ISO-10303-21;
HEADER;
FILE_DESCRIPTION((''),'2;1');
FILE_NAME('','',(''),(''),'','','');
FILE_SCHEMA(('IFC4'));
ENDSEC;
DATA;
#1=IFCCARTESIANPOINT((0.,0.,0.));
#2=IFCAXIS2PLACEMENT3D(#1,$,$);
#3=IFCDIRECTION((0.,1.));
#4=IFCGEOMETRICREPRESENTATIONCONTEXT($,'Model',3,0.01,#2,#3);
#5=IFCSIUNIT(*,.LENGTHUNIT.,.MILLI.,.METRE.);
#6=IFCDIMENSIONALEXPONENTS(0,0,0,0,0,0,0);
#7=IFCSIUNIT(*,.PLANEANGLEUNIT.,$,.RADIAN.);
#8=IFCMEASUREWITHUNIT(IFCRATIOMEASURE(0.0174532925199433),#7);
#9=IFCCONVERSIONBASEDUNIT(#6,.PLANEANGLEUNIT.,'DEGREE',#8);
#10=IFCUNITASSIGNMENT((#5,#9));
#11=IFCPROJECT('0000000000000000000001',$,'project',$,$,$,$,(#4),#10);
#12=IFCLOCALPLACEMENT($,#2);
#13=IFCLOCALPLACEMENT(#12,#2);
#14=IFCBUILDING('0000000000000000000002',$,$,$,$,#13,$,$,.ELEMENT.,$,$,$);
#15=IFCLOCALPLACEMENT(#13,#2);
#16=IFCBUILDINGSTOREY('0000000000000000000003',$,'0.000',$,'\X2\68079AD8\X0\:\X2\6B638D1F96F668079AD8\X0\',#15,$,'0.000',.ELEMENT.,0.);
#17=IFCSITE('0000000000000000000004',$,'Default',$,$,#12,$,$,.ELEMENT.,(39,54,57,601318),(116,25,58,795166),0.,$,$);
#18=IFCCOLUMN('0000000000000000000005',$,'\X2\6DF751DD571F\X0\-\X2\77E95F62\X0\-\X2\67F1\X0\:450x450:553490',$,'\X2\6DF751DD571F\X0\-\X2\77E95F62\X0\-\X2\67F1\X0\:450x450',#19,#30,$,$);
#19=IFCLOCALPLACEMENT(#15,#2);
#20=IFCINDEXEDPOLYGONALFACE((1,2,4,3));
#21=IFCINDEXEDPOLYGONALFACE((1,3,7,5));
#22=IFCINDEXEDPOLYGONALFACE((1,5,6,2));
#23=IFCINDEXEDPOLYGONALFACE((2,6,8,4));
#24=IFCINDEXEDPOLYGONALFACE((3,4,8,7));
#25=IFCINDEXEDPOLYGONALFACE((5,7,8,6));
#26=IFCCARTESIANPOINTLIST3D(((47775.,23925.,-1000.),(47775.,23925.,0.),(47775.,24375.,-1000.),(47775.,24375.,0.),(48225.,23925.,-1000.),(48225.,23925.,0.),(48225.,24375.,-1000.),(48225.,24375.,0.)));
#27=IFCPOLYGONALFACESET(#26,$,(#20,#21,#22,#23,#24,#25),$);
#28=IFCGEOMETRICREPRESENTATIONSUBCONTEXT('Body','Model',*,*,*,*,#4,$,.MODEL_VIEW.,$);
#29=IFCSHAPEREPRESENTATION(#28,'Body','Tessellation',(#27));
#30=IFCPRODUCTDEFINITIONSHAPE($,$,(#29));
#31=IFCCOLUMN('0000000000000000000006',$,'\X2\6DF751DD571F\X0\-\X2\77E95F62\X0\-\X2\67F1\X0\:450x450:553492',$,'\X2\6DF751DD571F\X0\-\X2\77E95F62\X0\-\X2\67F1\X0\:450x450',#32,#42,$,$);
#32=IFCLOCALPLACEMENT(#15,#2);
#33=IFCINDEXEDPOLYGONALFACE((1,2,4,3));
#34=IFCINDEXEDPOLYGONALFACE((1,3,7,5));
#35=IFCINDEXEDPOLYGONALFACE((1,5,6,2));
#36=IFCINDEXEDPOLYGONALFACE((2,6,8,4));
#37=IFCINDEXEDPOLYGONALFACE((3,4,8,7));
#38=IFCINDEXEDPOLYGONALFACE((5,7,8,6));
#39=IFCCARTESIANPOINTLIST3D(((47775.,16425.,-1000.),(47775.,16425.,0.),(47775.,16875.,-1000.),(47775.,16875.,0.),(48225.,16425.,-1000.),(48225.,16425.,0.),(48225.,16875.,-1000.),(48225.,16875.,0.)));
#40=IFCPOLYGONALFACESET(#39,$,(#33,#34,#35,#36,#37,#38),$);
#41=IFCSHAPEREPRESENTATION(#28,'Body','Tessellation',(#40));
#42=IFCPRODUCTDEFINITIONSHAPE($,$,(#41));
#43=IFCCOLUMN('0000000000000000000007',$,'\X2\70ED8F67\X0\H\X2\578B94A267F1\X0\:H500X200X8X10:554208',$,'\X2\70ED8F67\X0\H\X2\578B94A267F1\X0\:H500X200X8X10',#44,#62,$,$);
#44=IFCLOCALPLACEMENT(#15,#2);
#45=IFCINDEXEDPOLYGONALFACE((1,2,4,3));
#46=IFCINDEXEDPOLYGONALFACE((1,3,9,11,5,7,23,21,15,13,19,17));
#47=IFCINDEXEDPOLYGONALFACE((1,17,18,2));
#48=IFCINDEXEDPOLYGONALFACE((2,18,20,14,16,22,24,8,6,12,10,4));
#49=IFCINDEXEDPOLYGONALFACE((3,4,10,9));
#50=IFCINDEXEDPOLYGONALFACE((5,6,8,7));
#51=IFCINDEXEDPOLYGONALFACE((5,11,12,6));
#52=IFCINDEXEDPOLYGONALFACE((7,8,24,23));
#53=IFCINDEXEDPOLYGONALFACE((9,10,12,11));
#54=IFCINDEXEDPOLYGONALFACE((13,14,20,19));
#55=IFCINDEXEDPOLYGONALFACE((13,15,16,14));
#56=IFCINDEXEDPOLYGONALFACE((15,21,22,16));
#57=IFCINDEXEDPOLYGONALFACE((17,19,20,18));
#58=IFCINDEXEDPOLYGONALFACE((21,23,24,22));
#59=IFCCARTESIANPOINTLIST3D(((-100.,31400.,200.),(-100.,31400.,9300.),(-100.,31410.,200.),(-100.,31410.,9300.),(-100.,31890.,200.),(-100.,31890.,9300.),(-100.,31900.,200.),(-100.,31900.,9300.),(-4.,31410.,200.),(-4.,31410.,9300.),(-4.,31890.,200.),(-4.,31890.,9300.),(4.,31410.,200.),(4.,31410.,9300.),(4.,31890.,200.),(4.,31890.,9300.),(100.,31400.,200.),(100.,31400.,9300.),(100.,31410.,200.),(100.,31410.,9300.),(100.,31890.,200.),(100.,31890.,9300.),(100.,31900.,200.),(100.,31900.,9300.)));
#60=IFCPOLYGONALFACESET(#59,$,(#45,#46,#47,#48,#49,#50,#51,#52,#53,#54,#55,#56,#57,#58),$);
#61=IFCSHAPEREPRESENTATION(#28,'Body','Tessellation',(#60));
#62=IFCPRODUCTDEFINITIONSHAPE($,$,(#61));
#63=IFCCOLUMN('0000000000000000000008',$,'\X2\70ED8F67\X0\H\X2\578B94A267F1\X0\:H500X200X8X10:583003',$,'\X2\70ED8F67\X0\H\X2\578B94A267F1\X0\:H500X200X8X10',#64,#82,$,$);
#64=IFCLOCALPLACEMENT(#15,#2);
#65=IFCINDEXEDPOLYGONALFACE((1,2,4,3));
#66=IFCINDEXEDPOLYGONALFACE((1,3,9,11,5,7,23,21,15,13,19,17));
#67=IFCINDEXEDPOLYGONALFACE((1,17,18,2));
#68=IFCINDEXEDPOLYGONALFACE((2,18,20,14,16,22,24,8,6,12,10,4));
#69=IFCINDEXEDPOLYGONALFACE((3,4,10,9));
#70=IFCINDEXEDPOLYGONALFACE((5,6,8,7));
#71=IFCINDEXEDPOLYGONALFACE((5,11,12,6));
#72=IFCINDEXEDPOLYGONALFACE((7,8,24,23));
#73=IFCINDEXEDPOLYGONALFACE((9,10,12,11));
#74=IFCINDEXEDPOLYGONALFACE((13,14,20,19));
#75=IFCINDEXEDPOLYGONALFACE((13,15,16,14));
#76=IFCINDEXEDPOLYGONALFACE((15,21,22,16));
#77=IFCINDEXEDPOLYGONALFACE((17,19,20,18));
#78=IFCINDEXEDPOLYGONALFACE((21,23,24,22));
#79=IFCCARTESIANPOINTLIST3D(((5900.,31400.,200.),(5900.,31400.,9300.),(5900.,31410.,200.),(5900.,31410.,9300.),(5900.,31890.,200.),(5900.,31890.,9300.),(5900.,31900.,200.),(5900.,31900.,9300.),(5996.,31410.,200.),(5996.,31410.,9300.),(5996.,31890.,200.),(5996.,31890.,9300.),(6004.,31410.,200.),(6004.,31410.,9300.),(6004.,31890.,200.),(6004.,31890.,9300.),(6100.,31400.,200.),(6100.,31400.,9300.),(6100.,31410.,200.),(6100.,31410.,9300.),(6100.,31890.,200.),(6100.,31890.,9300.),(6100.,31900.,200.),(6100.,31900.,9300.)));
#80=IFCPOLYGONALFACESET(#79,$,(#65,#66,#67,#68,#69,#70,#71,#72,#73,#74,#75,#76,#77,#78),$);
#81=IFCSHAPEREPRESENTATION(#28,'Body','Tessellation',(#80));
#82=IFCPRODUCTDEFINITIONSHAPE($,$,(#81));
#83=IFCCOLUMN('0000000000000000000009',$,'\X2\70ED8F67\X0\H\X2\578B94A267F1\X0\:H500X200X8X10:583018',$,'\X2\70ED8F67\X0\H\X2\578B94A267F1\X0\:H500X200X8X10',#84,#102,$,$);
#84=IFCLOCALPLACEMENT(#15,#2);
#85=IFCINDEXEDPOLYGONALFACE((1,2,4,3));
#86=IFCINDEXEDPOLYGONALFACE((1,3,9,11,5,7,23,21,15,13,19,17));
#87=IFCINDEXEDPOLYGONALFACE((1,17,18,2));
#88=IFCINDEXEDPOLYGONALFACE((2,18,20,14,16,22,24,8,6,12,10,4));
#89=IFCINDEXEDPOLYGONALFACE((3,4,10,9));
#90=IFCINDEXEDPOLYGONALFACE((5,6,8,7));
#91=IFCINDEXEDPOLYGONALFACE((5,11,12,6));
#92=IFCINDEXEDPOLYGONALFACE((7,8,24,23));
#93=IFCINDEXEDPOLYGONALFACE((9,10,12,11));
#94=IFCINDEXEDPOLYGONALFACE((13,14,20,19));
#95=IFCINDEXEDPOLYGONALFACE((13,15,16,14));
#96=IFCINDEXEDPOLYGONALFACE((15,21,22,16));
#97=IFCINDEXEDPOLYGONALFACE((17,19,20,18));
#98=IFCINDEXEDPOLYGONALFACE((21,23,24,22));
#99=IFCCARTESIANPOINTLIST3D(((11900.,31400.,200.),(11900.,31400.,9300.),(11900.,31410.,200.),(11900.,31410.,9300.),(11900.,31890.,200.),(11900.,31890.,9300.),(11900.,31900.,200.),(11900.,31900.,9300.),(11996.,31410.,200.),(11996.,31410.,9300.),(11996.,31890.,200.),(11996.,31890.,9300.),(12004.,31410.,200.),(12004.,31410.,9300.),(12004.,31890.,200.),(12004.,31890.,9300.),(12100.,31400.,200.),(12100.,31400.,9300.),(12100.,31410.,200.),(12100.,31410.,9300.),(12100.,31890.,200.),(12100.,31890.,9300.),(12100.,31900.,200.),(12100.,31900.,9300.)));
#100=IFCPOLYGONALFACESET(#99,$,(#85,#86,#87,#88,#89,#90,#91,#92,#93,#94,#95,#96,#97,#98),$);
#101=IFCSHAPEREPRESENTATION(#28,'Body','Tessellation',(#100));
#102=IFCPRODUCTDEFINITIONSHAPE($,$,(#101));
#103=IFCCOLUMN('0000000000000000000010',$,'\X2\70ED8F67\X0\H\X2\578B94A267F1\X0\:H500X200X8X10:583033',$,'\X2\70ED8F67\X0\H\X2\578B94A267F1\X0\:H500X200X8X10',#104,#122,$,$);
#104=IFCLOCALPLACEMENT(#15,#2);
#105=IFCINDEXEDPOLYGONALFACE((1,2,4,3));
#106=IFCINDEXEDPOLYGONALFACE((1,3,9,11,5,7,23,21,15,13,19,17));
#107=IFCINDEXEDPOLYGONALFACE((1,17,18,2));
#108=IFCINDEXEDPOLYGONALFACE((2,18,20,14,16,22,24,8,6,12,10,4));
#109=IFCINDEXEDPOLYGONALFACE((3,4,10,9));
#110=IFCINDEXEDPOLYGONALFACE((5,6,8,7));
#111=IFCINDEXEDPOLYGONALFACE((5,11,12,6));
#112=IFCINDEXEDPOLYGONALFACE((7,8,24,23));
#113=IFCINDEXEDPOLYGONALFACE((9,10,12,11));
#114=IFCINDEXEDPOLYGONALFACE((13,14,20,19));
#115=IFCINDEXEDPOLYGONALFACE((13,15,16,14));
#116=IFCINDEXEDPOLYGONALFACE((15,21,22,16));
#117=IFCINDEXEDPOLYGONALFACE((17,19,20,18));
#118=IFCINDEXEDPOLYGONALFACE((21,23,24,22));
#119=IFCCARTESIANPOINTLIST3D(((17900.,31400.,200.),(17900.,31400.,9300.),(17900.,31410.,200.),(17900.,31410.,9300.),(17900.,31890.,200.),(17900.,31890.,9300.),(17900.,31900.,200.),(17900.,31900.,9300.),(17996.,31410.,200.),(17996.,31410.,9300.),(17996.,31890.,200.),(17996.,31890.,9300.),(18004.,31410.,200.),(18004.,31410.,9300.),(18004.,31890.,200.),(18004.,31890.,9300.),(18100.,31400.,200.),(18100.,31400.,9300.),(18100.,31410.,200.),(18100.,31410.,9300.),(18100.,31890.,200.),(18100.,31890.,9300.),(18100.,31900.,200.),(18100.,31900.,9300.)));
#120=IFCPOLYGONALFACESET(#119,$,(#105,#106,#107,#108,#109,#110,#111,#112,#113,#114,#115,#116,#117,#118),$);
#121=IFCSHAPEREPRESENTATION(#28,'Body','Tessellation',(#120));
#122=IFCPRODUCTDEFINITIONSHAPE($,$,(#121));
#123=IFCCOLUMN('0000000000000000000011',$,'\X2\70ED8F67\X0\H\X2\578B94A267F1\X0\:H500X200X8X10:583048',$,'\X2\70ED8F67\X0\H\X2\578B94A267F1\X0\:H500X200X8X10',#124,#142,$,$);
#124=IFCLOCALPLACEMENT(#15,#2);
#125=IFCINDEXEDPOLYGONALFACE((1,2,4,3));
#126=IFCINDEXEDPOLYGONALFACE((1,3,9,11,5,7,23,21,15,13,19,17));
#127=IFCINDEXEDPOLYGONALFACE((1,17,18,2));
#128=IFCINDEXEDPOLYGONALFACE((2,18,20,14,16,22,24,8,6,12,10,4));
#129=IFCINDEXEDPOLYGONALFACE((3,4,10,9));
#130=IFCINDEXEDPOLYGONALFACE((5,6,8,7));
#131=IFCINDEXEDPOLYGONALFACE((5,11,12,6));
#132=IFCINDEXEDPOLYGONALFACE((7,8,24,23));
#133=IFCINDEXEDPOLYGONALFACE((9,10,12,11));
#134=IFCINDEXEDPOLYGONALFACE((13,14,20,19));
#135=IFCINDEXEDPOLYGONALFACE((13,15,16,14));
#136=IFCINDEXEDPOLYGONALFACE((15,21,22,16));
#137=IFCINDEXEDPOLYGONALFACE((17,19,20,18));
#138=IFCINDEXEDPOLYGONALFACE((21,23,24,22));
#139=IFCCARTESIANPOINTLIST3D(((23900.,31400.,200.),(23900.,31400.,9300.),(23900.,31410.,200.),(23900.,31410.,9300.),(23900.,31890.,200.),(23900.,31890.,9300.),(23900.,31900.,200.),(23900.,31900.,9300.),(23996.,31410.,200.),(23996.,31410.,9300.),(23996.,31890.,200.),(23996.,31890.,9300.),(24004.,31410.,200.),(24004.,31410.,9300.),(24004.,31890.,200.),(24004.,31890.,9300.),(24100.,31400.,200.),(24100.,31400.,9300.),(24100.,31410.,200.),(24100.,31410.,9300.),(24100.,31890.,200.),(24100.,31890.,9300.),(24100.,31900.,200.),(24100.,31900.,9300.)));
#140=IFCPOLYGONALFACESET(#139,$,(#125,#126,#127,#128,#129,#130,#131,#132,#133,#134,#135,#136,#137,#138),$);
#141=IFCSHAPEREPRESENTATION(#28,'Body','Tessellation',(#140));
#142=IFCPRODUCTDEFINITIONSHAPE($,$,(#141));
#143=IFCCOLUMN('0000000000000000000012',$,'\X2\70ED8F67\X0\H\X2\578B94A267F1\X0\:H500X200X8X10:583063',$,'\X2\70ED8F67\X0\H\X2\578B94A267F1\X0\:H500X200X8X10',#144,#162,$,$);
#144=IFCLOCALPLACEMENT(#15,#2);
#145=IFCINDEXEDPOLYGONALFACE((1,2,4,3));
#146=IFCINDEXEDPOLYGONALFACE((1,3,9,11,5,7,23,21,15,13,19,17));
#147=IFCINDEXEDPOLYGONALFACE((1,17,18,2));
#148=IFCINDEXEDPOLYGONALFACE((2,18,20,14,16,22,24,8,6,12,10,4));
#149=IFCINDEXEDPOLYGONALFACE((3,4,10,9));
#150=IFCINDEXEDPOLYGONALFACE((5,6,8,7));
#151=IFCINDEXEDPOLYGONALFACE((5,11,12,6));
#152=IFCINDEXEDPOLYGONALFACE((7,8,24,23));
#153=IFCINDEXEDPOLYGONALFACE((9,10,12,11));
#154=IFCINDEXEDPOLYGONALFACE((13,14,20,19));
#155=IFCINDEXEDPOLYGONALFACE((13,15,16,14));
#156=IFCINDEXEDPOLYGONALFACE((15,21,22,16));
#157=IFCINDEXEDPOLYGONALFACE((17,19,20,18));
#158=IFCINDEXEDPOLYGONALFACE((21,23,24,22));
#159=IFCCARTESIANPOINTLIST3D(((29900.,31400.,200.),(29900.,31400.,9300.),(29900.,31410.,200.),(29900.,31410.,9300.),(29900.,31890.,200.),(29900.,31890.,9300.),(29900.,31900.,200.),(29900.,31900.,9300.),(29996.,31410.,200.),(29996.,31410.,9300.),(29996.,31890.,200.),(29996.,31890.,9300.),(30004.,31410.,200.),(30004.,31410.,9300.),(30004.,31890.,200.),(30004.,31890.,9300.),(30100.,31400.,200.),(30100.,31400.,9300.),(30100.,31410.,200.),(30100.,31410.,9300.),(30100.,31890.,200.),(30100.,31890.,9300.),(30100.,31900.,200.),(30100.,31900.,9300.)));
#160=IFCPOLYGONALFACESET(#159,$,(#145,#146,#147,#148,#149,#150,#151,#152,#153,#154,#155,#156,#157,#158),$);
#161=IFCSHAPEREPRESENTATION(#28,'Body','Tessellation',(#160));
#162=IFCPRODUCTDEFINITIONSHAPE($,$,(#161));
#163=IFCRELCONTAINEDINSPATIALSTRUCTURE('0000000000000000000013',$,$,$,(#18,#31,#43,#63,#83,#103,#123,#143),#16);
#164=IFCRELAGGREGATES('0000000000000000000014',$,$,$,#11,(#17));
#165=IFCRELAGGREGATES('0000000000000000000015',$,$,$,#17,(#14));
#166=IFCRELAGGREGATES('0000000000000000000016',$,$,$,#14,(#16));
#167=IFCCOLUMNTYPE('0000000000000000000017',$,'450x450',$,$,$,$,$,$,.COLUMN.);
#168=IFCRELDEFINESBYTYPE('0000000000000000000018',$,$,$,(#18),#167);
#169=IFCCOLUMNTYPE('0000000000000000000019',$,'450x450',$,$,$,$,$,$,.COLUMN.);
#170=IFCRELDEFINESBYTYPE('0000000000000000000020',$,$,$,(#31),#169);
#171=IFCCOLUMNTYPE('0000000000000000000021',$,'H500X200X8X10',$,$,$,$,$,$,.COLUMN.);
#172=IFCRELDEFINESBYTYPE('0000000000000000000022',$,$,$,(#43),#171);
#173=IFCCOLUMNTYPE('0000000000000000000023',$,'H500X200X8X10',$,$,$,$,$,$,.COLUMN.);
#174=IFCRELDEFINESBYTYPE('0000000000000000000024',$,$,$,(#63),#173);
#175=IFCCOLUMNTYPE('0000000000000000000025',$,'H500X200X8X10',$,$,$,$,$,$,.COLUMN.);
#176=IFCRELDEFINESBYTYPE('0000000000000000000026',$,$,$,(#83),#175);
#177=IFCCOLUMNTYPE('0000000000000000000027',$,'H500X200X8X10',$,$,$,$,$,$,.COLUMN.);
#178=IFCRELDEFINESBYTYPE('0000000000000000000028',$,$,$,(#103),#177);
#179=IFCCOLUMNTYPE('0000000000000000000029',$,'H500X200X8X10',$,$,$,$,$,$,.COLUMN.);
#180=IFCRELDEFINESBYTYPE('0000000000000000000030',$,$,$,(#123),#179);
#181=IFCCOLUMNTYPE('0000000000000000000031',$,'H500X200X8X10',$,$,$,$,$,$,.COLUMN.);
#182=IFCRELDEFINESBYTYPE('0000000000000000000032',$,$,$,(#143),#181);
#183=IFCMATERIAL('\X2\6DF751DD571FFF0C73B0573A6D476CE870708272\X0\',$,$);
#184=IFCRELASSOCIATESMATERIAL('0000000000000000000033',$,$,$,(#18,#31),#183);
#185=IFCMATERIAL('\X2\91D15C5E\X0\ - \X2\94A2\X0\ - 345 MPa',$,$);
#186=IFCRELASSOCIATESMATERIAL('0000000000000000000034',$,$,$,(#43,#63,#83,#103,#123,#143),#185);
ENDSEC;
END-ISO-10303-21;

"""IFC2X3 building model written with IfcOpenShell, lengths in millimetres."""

from ifc_helpers import new_model, entity, si_unit, converted_unit, direction, frame, origin, origin_2d_with_axis, place, context, subcontext, project, spatial, polyline, rectangle, outline, extrude, source, transform, mapped, material, type_object, type_shapes, element, save


model = new_model("IFC2X3")

# Units and contexts
model_context = context("Model", 3, precision=0.01, world=origin(), true_north=direction((0.0, 1.0)))
body_context = subcontext(model_context, "Body", "Model", "MODEL_VIEW")
ifc_project = project(units=[si_unit("LENGTHUNIT", "METRE", prefix="MILLI"), converted_unit("PLANEANGLEUNIT", "DEGREE", entity("IfcRatioMeasure", 0.0174532925199433), si_unit("PLANEANGLEUNIT", "RADIAN"), dimensions=[0, 0, 0, 0, 0, 0, 0])], contexts=[model_context])

# Site, building, storey
site_placement = place(None, origin())
site = spatial("IfcSite", under=ifc_project, at=site_placement, Name="Default", CompositionType="ELEMENT", RefLatitude=(39, 54, 57, 601318), RefLongitude=(116, 25, 58, 795166), RefElevation=0.0)
building_placement = place(site_placement, origin())
building = spatial("IfcBuilding", under=site, at=building_placement, CompositionType="ELEMENT")
storey_placement = place(building_placement, origin())
storey = spatial("IfcBuildingStorey", under=building, at=storey_placement, Name="0.000", ObjectType="标高:正负零标高", LongName="0.000", CompositionType="ELEMENT", Elevation=0.0)

# Columns
ifc_material_1 = material(Name="混凝土，现场浇注灰色")
column_type_1 = type_object("IfcColumnType", Name="450x450", PredefinedType="COLUMN")
shared_shape_1 = source(origin(), body_context, "Body", "SweptSolid", [
    extrude(rectangle(XDim=450.0, YDim=450.0, at=origin_2d_with_axis()), frame((48000.0, 24150.0, -1000.0), z_axis=(0.0, 0.0, 1.0), x_axis=(0.0, -1.0, 0.0)), (0.0, 0.0, 1.0), 1000.0),
])
type_shapes(column_type_1, [shared_shape_1])
column_1_placement = place(storey_placement, origin())
element("IfcColumn", 1, at=column_1_placement, inside=storey, type_object=column_type_1, material=ifc_material_1, Name="混凝土-矩形-柱:450x450:553490", ObjectType="混凝土-矩形-柱:450x450", context=body_context, shape_type="MappedRepresentation", body=[
    mapped(shared_shape_1, transform((0.0, 0.0, 0.0), scale=1.0)),
])
column_type_2 = type_object("IfcColumnType", Name="450x450", PredefinedType="COLUMN")
shared_shape_2 = source(origin(), body_context, "Body", "SweptSolid", [
    extrude(rectangle(XDim=450.0, YDim=450.0, at=origin_2d_with_axis()), frame((48000.0, 16650.0, -1000.0), z_axis=(0.0, 0.0, 1.0), x_axis=(0.0, -1.0, 0.0)), (0.0, 0.0, 1.0), 1000.0),
])
type_shapes(column_type_2, [shared_shape_2])
column_2_placement = place(storey_placement, origin())
element("IfcColumn", 2, at=column_2_placement, inside=storey, type_object=column_type_2, material=ifc_material_1, Name="混凝土-矩形-柱:450x450:553492", ObjectType="混凝土-矩形-柱:450x450", context=body_context, shape_type="MappedRepresentation", body=[
    mapped(shared_shape_2, transform((0.0, 0.0, 0.0), scale=1.0)),
])
ifc_material_2 = material(Name="金属 - 钢 - 345 MPa")
column_type_3 = type_object("IfcColumnType", Name="H500X200X8X10", PredefinedType="COLUMN")
shared_shape_3 = source(origin(), body_context, "Body", "SweptSolid", [
    extrude(outline(polyline([(240.0, -100.0), (250.0, -100.0), (250.0, 100.0), (240.0, 100.0), (240.0, 4.0), (-240.0, 4.0), (-240.0, 100.0), (-250.0, 100.0), (-250.0, -100.0), (-240.0, -100.0), (-240.0, -4.0), (240.0, -4.0), (240.0, -100.0)])), frame((0.0, 31650.0, 200.0), z_axis=(0.0, 0.0, 1.0), x_axis=(0.0, -1.0, 0.0)), (0.0, 0.0, 1.0), 9100.0),
])
type_shapes(column_type_3, [shared_shape_3])
column_3_placement = place(storey_placement, origin())
element("IfcColumn", 3, at=column_3_placement, inside=storey, type_object=column_type_3, material=ifc_material_2, Name="热轧H型钢柱:H500X200X8X10:554208", ObjectType="热轧H型钢柱:H500X200X8X10", context=body_context, shape_type="MappedRepresentation", body=[
    mapped(shared_shape_3, transform((0.0, 0.0, 0.0), scale=1.0)),
])
column_type_4 = type_object("IfcColumnType", Name="H500X200X8X10", PredefinedType="COLUMN")
shared_shape_4 = source(origin(), body_context, "Body", "SweptSolid", [
    extrude(outline(polyline([(240.0, -100.0), (250.0, -100.0), (250.0, 100.0), (240.0, 100.0), (240.0, 4.0), (-240.0, 4.0), (-240.0, 100.0), (-250.0, 100.0), (-250.0, -100.0), (-240.0, -100.0), (-240.0, -4.0), (240.0, -4.0), (240.0, -100.0)])), frame((6000.0, 31650.0, 200.0), z_axis=(0.0, 0.0, 1.0), x_axis=(0.0, -1.0, 0.0)), (0.0, 0.0, 1.0), 9100.0),
])
type_shapes(column_type_4, [shared_shape_4])
column_4_placement = place(storey_placement, origin())
element("IfcColumn", 4, at=column_4_placement, inside=storey, type_object=column_type_4, material=ifc_material_2, Name="热轧H型钢柱:H500X200X8X10:583003", ObjectType="热轧H型钢柱:H500X200X8X10", context=body_context, shape_type="MappedRepresentation", body=[
    mapped(shared_shape_4, transform((0.0, 0.0, 0.0), scale=1.0)),
])
column_type_5 = type_object("IfcColumnType", Name="H500X200X8X10", PredefinedType="COLUMN")
shared_shape_5 = source(origin(), body_context, "Body", "SweptSolid", [
    extrude(outline(polyline([(240.0, -100.0), (250.0, -100.0), (250.0, 100.0), (240.0, 100.0), (240.0, 4.0), (-240.0, 4.0), (-240.0, 100.0), (-250.0, 100.0), (-250.0, -100.0), (-240.0, -100.0), (-240.0, -4.0), (240.0, -4.0), (240.0, -100.0)])), frame((12000.0, 31650.0, 200.0), z_axis=(0.0, 0.0, 1.0), x_axis=(0.0, -1.0, 0.0)), (0.0, 0.0, 1.0), 9100.0),
])
type_shapes(column_type_5, [shared_shape_5])
column_5_placement = place(storey_placement, origin())
element("IfcColumn", 5, at=column_5_placement, inside=storey, type_object=column_type_5, material=ifc_material_2, Name="热轧H型钢柱:H500X200X8X10:583018", ObjectType="热轧H型钢柱:H500X200X8X10", context=body_context, shape_type="MappedRepresentation", body=[
    mapped(shared_shape_5, transform((0.0, 0.0, 0.0), scale=1.0)),
])
column_type_6 = type_object("IfcColumnType", Name="H500X200X8X10", PredefinedType="COLUMN")
shared_shape_6 = source(origin(), body_context, "Body", "SweptSolid", [
    extrude(outline(polyline([(240.0, -100.0), (250.0, -100.0), (250.0, 100.0), (240.0, 100.0), (240.0, 4.0), (-240.0, 4.0), (-240.0, 100.0), (-250.0, 100.0), (-250.0, -100.0), (-240.0, -100.0), (-240.0, -4.0), (240.0, -4.0), (240.0, -100.0)])), frame((18000.0, 31650.0, 200.0), z_axis=(0.0, 0.0, 1.0), x_axis=(0.0, -1.0, 0.0)), (0.0, 0.0, 1.0), 9100.0),
])
type_shapes(column_type_6, [shared_shape_6])
column_6_placement = place(storey_placement, origin())
element("IfcColumn", 6, at=column_6_placement, inside=storey, type_object=column_type_6, material=ifc_material_2, Name="热轧H型钢柱:H500X200X8X10:583033", ObjectType="热轧H型钢柱:H500X200X8X10", context=body_context, shape_type="MappedRepresentation", body=[
    mapped(shared_shape_6, transform((0.0, 0.0, 0.0), scale=1.0)),
])
column_type_7 = type_object("IfcColumnType", Name="H500X200X8X10", PredefinedType="COLUMN")
shared_shape_7 = source(origin(), body_context, "Body", "SweptSolid", [
    extrude(outline(polyline([(240.0, -100.0), (250.0, -100.0), (250.0, 100.0), (240.0, 100.0), (240.0, 4.0), (-240.0, 4.0), (-240.0, 100.0), (-250.0, 100.0), (-250.0, -100.0), (-240.0, -100.0), (-240.0, -4.0), (240.0, -4.0), (240.0, -100.0)])), frame((24000.0, 31650.0, 200.0), z_axis=(0.0, 0.0, 1.0), x_axis=(0.0, -1.0, 0.0)), (0.0, 0.0, 1.0), 9100.0),
])
type_shapes(column_type_7, [shared_shape_7])
column_7_placement = place(storey_placement, origin())
element("IfcColumn", 7, at=column_7_placement, inside=storey, type_object=column_type_7, material=ifc_material_2, Name="热轧H型钢柱:H500X200X8X10:583048", ObjectType="热轧H型钢柱:H500X200X8X10", context=body_context, shape_type="MappedRepresentation", body=[
    mapped(shared_shape_7, transform((0.0, 0.0, 0.0), scale=1.0)),
])
column_type_8 = type_object("IfcColumnType", Name="H500X200X8X10", PredefinedType="COLUMN")
shared_shape_8 = source(origin(), body_context, "Body", "SweptSolid", [
    extrude(outline(polyline([(240.0, -100.0), (250.0, -100.0), (250.0, 100.0), (240.0, 100.0), (240.0, 4.0), (-240.0, 4.0), (-240.0, 100.0), (-250.0, 100.0), (-250.0, -100.0), (-240.0, -100.0), (-240.0, -4.0), (240.0, -4.0), (240.0, -100.0)])), frame((30000.0, 31650.0, 200.0), z_axis=(0.0, 0.0, 1.0), x_axis=(0.0, -1.0, 0.0)), (0.0, 0.0, 1.0), 9100.0),
])
type_shapes(column_type_8, [shared_shape_8])
column_8_placement = place(storey_placement, origin())
element("IfcColumn", 8, at=column_8_placement, inside=storey, type_object=column_type_8, material=ifc_material_2, Name="热轧H型钢柱:H500X200X8X10:583063", ObjectType="热轧H型钢柱:H500X200X8X10", context=body_context, shape_type="MappedRepresentation", body=[
    mapped(shared_shape_8, transform((0.0, 0.0, 0.0), scale=1.0)),
])

save(model, "model.ifc")
